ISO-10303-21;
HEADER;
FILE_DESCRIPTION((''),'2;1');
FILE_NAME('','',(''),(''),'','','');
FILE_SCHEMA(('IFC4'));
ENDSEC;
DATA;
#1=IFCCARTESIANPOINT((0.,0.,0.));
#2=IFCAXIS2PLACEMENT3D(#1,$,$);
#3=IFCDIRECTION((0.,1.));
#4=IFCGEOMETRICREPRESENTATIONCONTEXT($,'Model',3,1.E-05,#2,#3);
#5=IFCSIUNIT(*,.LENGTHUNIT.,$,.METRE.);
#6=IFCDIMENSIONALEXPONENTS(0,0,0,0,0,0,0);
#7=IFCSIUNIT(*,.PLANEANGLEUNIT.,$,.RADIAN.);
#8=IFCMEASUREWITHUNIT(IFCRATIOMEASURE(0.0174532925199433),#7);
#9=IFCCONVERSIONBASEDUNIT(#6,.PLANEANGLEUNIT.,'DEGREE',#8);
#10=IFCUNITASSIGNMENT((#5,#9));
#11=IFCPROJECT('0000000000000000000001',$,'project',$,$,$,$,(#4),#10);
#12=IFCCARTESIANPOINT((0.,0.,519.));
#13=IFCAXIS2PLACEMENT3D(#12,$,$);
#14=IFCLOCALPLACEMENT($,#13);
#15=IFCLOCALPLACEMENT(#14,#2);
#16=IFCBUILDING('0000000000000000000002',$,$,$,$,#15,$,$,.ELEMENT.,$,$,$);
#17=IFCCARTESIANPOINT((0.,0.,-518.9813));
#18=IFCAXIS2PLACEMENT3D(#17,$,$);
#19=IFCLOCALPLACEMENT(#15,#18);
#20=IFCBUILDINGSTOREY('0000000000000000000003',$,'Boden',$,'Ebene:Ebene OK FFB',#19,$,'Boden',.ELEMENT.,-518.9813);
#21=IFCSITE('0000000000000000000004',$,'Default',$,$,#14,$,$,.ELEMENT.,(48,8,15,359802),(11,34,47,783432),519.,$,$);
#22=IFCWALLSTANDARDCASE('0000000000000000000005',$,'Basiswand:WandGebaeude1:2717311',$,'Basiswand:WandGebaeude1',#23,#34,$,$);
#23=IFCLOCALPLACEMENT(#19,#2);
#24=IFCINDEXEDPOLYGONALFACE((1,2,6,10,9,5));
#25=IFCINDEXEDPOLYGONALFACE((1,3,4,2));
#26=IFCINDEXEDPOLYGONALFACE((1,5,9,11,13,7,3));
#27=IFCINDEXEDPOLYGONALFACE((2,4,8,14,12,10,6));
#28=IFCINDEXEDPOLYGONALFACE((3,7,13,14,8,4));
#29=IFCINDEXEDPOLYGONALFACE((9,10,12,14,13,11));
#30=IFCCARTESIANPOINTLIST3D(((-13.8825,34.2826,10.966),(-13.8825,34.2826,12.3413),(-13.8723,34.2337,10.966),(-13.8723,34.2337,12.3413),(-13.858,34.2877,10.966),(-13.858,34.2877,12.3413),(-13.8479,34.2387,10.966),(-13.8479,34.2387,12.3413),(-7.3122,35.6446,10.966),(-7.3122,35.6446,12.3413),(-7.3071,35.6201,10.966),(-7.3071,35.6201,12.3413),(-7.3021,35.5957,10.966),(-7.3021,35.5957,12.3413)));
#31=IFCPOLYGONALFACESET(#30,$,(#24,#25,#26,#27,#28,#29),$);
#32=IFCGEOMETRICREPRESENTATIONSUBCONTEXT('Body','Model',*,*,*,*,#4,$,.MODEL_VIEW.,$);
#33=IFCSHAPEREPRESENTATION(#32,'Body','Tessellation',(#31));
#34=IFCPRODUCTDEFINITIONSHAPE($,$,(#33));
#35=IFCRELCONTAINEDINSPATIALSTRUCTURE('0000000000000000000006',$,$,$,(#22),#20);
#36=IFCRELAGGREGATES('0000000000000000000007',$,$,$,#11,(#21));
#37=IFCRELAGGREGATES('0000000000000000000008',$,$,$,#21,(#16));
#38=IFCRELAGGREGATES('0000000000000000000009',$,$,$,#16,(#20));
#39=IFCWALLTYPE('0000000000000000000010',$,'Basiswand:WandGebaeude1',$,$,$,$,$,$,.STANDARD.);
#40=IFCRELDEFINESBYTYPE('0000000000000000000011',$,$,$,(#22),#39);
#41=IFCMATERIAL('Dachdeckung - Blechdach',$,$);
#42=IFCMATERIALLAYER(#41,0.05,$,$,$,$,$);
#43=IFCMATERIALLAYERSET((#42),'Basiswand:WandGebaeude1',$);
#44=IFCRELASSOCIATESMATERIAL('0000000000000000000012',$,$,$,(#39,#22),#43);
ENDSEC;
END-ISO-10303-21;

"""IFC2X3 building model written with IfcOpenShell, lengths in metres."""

from ifc_helpers import new_model, entity, si_unit, converted_unit, direction, frame, origin, place, context, subcontext, project, spatial, polyline, outline, extrude, material, layer, layer_set, layer_usage, type_object, element, save


model = new_model("IFC2X3")

# Units and contexts
model_context = context("Model", 3, precision=1e-05, world=origin(), true_north=direction((0.0, 1.0)))
body_context = subcontext(model_context, "Body", "Model", "MODEL_VIEW")
ifc_project = project(units=[si_unit("LENGTHUNIT", "METRE"), converted_unit("PLANEANGLEUNIT", "DEGREE", entity("IfcRatioMeasure", 0.0174532925199433), si_unit("PLANEANGLEUNIT", "RADIAN"), dimensions=[0, 0, 0, 0, 0, 0, 0])], contexts=[model_context])

# Site, building, storey
site_placement = place(None, frame((0.0, 0.0, 519.0)))
site = spatial("IfcSite", under=ifc_project, at=site_placement, Name="Default", CompositionType="ELEMENT", RefLatitude=(48, 8, 15, 359802), RefLongitude=(11, 34, 47, 783432), RefElevation=519.0)
building_placement = place(site_placement, origin())
building = spatial("IfcBuilding", under=site, at=building_placement, CompositionType="ELEMENT")
storey_placement = place(building_placement, frame((0.0, 0.0, -518.9813)))
storey = spatial("IfcBuildingStorey", under=building, at=storey_placement, Name="Boden", ObjectType="Ebene:Ebene OK FFB", LongName="Boden", CompositionType="ELEMENT", Elevation=-518.9813)

# Wall
ifc_material_1 = material(Name="Dachdeckung - Blechdach")
ifc_layer = layer(ifc_material_1, 0.05)
ifc_layer_set = layer_set([ifc_layer], Name="Basiswand:WandGebaeude1")
ifc_layer_usage = layer_usage(ifc_layer_set, "AXIS2", "NEGATIVE", 0.025)
wall_type = type_object("IfcWallType", Name="Basiswand:WandGebaeude1", PredefinedType="STANDARD", material=ifc_layer_set)
wall_placement = place(storey_placement, frame((-13.8774, 34.2581, 10.966), z_axis=(0.0, 0.0, 1.0), x_axis=(0.979183, 0.20298, 0.0)))
element("IfcWallStandardCase", 1, at=wall_placement, inside=storey, type_object=wall_type, material=ifc_layer_usage, Name="Basiswand:WandGebaeude1:2717311", ObjectType="Basiswand:WandGebaeude1", context=body_context, shape_type="SweptSolid", body=[
    extrude(outline(polyline([(6.71, -0.025), (6.7099, 0.0), (6.7099, 0.025), (0.025, 0.025), (0.0, 0.025), (0.0, -0.025), (0.025, -0.025), (6.71, -0.025)])), origin(), (0.0, 0.0, 1.0), 1.3753),
])

save(model, "model.ifc")
